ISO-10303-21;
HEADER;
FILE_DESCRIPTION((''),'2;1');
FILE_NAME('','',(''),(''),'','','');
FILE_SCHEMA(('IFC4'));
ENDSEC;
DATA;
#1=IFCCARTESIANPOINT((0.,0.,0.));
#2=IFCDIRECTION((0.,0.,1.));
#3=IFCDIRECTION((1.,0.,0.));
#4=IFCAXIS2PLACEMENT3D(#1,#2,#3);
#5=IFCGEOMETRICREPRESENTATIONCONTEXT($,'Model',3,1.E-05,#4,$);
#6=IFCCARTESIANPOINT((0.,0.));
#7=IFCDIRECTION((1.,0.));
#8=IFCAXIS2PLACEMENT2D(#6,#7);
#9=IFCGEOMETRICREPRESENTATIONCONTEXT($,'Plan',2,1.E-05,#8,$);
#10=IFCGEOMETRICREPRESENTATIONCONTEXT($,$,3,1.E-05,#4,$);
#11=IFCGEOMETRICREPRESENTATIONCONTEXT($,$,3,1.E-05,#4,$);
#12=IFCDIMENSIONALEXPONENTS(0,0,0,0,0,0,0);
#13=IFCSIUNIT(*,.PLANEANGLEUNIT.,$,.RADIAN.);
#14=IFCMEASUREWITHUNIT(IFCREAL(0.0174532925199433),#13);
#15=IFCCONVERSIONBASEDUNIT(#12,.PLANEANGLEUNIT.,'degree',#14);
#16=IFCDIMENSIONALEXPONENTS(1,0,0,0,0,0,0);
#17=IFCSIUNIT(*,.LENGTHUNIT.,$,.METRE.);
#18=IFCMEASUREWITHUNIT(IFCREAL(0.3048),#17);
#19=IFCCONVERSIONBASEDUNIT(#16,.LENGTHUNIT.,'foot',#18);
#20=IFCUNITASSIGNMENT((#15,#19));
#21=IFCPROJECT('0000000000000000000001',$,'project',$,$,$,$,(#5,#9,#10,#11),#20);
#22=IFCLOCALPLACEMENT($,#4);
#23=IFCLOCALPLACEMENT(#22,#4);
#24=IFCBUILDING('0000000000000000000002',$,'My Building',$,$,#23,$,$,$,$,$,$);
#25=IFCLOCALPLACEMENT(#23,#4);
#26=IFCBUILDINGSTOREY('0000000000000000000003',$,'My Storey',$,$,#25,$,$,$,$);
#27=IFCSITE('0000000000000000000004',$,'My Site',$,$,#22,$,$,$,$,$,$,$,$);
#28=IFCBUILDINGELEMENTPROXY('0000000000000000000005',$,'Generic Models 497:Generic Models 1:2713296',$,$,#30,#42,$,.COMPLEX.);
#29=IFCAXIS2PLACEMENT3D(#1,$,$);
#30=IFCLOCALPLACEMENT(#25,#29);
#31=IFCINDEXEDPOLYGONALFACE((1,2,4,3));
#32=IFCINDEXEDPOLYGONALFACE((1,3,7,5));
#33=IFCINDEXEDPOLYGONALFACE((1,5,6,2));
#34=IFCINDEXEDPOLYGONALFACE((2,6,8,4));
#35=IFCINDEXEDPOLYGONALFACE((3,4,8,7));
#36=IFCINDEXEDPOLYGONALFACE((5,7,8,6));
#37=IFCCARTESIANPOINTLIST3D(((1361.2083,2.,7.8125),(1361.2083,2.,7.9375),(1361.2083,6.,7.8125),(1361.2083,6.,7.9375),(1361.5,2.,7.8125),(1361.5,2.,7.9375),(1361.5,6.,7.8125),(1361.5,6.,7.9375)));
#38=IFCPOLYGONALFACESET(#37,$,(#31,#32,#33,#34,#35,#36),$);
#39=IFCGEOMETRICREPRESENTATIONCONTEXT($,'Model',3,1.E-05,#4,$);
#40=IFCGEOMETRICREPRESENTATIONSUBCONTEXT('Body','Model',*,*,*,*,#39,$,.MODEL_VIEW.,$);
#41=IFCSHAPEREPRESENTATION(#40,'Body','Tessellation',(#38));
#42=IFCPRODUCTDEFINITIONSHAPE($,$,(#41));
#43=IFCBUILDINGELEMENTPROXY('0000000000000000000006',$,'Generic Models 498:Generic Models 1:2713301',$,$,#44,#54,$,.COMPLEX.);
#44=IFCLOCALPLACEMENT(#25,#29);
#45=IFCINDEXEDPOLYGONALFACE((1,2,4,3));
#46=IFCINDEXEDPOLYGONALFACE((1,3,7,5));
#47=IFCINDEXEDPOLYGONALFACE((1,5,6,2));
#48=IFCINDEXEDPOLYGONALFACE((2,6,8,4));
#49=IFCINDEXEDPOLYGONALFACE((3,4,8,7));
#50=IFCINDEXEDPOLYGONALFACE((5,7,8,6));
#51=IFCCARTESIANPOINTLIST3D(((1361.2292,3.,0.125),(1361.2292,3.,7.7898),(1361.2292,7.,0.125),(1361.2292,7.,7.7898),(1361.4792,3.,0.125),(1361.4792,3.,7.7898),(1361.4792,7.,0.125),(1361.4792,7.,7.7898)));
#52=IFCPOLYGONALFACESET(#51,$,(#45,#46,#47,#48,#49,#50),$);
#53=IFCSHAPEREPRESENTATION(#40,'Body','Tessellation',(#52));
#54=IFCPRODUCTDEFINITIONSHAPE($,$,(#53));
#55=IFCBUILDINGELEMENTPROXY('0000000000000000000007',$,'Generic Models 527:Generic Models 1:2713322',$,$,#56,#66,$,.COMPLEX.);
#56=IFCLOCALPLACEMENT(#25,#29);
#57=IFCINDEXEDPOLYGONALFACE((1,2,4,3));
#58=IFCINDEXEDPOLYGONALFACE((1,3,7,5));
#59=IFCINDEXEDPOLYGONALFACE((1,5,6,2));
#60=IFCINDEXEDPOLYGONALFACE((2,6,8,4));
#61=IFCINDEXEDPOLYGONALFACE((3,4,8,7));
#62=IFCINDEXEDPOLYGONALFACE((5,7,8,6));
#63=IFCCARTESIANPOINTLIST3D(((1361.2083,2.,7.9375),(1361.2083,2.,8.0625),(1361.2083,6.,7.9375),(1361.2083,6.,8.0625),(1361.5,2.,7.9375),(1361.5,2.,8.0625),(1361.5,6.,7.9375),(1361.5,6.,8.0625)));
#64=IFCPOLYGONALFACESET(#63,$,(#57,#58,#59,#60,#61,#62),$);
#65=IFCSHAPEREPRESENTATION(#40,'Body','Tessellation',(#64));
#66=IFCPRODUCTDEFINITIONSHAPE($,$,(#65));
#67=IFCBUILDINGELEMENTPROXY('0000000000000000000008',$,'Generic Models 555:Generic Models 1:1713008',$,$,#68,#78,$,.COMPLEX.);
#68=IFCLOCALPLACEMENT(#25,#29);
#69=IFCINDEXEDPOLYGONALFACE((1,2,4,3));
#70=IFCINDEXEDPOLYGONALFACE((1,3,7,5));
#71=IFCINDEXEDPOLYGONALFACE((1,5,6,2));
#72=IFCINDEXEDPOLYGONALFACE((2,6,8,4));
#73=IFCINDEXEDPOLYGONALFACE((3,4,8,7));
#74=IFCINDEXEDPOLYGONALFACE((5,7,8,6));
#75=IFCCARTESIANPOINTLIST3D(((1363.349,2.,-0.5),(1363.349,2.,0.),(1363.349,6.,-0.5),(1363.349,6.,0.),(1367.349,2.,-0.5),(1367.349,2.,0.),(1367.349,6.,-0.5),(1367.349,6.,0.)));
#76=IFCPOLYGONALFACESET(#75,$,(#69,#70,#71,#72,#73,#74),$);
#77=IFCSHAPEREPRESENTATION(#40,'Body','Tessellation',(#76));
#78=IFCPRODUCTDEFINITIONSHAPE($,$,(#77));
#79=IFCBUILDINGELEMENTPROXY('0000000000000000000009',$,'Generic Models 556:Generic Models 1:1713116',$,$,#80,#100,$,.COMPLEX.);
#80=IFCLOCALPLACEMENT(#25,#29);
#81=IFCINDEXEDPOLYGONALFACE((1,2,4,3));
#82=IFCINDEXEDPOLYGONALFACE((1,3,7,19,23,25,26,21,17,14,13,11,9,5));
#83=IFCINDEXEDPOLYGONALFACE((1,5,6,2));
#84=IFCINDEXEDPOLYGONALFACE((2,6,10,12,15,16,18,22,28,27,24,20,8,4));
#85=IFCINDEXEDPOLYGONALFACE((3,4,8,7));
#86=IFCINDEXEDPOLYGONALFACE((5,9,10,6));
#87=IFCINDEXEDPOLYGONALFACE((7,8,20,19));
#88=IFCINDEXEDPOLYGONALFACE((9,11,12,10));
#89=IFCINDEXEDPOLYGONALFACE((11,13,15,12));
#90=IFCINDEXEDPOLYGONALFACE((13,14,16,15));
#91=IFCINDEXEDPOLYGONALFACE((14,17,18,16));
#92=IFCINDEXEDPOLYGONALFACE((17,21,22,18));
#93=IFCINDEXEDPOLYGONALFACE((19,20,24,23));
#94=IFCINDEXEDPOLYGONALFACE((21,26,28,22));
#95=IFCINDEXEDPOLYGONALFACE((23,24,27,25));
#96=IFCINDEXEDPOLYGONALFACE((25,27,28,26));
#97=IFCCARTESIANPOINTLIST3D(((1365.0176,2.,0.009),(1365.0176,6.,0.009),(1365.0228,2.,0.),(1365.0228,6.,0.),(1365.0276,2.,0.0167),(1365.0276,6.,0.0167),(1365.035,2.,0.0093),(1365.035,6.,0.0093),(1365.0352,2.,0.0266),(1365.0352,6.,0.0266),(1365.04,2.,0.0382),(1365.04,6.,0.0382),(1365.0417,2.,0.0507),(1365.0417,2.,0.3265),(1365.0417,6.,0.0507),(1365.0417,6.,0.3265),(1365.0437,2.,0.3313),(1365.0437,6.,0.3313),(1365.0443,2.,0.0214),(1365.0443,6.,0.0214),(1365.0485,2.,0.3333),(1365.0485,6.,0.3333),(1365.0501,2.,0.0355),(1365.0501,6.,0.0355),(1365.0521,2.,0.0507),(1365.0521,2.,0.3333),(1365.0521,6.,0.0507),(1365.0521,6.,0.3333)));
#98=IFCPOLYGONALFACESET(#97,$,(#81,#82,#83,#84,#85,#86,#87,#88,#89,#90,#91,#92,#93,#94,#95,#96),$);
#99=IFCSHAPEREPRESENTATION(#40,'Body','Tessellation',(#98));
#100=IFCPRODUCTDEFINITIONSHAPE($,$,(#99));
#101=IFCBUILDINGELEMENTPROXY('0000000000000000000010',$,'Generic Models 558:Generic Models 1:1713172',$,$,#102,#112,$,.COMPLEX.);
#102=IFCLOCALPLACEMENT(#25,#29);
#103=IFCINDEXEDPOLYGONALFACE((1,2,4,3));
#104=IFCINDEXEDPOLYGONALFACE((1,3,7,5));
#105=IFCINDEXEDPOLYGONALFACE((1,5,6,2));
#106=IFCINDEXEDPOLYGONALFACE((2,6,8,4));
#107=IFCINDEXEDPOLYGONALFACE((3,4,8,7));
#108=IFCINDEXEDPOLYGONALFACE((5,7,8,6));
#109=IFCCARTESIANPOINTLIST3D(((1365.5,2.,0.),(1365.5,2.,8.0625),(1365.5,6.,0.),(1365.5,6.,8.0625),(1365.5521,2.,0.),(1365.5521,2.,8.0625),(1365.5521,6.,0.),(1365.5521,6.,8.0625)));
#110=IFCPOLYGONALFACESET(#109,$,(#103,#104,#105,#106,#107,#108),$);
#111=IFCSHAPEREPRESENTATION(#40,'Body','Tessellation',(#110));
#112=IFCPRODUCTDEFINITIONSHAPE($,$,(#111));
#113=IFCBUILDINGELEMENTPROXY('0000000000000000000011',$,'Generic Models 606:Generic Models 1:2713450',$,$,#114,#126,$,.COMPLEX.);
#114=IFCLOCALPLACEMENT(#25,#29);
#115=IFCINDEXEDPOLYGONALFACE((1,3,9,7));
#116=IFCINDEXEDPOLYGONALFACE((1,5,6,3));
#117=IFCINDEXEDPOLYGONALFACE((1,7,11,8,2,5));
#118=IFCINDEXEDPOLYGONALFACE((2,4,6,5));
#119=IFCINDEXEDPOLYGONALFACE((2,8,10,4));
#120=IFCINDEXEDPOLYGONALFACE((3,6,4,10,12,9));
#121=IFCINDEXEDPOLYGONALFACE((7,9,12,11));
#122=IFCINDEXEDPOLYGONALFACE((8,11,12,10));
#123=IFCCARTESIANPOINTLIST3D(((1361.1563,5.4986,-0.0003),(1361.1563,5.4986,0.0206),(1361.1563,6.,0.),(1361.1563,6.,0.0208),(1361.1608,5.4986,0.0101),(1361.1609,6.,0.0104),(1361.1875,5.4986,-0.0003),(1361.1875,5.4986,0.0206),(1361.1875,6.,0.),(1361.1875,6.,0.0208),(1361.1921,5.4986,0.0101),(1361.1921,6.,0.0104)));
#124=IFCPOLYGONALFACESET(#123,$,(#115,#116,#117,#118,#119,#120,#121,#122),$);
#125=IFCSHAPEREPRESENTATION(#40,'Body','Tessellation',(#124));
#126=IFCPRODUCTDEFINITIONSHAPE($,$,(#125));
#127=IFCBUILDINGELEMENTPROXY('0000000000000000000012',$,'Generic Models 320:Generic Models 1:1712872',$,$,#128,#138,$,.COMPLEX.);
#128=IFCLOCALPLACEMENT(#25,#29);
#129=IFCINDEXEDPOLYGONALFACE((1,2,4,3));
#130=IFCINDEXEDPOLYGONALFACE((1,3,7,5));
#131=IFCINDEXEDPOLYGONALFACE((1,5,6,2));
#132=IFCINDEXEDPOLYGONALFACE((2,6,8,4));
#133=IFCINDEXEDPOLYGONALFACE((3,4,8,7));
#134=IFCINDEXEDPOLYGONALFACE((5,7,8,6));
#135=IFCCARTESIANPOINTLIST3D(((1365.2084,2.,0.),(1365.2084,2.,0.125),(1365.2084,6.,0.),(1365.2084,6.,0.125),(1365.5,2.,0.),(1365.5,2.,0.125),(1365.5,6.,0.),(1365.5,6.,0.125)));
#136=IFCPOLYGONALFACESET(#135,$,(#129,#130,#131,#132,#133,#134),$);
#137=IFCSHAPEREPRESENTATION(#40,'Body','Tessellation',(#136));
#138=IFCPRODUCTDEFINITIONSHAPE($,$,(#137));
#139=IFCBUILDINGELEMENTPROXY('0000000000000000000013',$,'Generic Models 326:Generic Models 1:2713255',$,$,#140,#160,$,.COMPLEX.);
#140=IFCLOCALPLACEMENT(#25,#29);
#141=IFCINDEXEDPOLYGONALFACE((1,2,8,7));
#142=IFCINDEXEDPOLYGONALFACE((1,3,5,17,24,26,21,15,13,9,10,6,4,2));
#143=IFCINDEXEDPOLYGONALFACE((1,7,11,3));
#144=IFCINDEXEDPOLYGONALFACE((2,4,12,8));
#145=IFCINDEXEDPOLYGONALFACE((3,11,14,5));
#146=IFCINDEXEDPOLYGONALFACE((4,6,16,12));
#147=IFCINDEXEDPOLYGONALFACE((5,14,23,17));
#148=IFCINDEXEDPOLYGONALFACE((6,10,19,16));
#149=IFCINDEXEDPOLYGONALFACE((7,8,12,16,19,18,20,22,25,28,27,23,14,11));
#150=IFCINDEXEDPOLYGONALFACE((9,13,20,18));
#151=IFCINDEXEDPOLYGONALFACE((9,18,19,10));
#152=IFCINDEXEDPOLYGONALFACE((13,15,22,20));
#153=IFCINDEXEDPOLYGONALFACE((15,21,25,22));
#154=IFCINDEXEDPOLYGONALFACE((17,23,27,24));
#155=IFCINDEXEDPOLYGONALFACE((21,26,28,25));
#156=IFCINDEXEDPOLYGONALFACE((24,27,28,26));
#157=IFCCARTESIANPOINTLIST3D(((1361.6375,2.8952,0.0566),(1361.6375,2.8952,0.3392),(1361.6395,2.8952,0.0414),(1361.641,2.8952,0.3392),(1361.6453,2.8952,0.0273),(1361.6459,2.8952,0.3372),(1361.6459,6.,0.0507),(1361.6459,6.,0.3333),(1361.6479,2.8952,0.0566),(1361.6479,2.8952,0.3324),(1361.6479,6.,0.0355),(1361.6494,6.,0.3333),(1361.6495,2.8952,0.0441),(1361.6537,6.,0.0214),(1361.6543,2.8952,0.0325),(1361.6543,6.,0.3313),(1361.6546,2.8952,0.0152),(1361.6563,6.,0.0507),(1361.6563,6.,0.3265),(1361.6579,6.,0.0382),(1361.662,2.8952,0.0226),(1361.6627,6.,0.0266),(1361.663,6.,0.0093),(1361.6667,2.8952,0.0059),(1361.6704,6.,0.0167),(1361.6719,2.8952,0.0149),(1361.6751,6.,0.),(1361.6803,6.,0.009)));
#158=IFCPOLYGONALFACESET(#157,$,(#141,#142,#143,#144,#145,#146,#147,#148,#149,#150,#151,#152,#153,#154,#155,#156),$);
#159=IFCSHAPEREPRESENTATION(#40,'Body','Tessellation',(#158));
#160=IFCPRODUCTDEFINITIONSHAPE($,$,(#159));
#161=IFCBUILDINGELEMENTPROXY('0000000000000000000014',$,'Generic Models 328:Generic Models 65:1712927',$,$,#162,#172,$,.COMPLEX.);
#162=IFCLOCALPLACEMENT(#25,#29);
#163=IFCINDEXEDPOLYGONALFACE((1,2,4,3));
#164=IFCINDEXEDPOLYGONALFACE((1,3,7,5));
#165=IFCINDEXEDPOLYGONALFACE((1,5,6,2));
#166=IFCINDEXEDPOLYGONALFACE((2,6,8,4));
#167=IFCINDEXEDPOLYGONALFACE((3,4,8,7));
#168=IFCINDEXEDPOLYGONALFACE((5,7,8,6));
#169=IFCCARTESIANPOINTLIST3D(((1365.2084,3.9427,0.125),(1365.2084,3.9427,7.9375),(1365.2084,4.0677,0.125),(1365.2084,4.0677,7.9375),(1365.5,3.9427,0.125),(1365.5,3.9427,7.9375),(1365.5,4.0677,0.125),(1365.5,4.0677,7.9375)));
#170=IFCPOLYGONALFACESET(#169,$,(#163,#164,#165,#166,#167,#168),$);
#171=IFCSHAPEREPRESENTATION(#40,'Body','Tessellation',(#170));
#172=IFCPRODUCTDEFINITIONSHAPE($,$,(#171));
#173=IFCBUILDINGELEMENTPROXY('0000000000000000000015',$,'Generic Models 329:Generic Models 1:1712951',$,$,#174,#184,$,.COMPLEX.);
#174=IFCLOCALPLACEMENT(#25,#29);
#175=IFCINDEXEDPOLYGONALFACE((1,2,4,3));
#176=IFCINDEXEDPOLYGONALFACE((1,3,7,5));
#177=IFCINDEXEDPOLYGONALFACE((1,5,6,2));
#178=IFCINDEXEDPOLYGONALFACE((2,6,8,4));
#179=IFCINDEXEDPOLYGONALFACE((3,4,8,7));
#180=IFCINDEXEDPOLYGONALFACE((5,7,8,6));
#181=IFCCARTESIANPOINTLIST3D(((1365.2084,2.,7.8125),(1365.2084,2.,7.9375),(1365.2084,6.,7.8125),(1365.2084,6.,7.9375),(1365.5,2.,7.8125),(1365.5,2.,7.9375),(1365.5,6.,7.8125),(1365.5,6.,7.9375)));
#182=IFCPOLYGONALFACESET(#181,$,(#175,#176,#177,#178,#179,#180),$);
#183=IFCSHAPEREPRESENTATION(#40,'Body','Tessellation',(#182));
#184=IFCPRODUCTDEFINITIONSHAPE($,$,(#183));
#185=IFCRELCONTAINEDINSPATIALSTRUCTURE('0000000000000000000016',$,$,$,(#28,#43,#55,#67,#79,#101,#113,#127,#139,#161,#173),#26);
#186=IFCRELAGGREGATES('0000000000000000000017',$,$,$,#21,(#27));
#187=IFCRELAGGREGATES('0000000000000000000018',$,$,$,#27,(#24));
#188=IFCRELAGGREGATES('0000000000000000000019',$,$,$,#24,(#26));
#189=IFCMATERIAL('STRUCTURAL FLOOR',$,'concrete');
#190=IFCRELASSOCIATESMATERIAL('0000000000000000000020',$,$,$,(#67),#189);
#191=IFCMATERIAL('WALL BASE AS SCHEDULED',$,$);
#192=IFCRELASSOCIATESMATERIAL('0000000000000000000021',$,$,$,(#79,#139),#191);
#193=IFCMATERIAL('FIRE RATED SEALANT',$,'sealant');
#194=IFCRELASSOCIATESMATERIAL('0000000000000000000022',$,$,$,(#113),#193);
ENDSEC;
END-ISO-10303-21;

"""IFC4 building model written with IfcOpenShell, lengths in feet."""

from ifc_helpers import new_model, entity, si_unit, converted_unit, frame, origin_with_axes, origin_2d_with_axis, place, context, subcontext, project, spatial, polyline, outline, extrude, material, element, save


model = new_model("IFC4")

# Units and contexts
model_context_1 = context("Model", 3, precision=1e-05, world=origin_with_axes())
plan_context = context("Plan", 2, precision=1e-05, world=origin_2d_with_axis())
model_context_2 = context("Model", 3, precision=1e-05, world=origin_with_axes())
context_of_model_1 = context(None, 3, precision=1e-05, world=origin_with_axes())
context_of_model_2 = context(None, 3, precision=1e-05, world=origin_with_axes())
body_context = subcontext(model_context_2, "Body", "Model", "MODEL_VIEW")
ifc_project = project(units=[converted_unit("PLANEANGLEUNIT", "degree", entity("IfcReal", 0.0174532925199433), si_unit("PLANEANGLEUNIT", "RADIAN"), dimensions=[0, 0, 0, 0, 0, 0, 0]), converted_unit("LENGTHUNIT", "foot", entity("IfcReal", 0.3048), si_unit("LENGTHUNIT", "METRE"), dimensions=[1, 0, 0, 0, 0, 0, 0])], contexts=[model_context_1, plan_context, context_of_model_1, context_of_model_2])

# Site, building, storey
site_placement = place(None, origin_with_axes())
site = spatial("IfcSite", under=ifc_project, at=site_placement, Name="My Site")
building_placement = place(site_placement, origin_with_axes())
building = spatial("IfcBuilding", under=site, at=building_placement, Name="My Building")
storey_placement = place(building_placement, origin_with_axes())
storey = spatial("IfcBuildingStorey", under=building, at=storey_placement, Name="My Storey")

# Building element proxies
proxy_1_placement = place(storey_placement, frame((1361.2083, 6.0, 7.8125), z_axis=(0.0, -1.0, 0.0), x_axis=(0.0, 0.0, 1.0)))
element("IfcBuildingElementProxy", 1, at=proxy_1_placement, inside=storey, Name="Generic Models 497:Generic Models 1:2713296", PredefinedType="COMPLEX", context=body_context, shape_type="SweptSolid", body=[
    extrude(outline(polyline([(-0.1458, -0.0625), (0.1458, -0.0625), (0.1458, 0.0625), (-0.1458, 0.0625), (-0.1458, -0.0625)])), frame((0.0625, -0.1458, 0.0), z_axis=(0.0, 0.0, -1.0), x_axis=(0.0, 1.0, 0.0)), (0.0, 0.0, -1.0), 4.0),
])
proxy_2_placement = place(storey_placement, frame((1361.2292, 3.0, 0.125), z_axis=(0.0, 0.0, 1.0), x_axis=(0.0, 1.0, 0.0)))
element("IfcBuildingElementProxy", 2, at=proxy_2_placement, inside=storey, Name="Generic Models 498:Generic Models 1:2713301", PredefinedType="COMPLEX", context=body_context, shape_type="SweptSolid", body=[
    extrude(outline(polyline([(-2.0, -0.125), (2.0, -0.125), (2.0, 0.125), (-2.0, 0.125), (-2.0, -0.125)])), frame((2.0, -0.125, 0.0), z_axis=(0.0, 0.0, -1.0), x_axis=(-1.0, 0.0, 0.0)), (0.0, 0.0, -1.0), 7.6648),
])
proxy_3_placement = place(storey_placement, frame((1361.2083, 6.0, 7.9375), z_axis=(0.0, -1.0, 0.0), x_axis=(0.0, 0.0, 1.0)))
element("IfcBuildingElementProxy", 3, at=proxy_3_placement, inside=storey, Name="Generic Models 527:Generic Models 1:2713322", PredefinedType="COMPLEX", context=body_context, shape_type="SweptSolid", body=[
    extrude(outline(polyline([(-0.1458, -0.0625), (0.1458, -0.0625), (0.1458, 0.0625), (-0.1458, 0.0625), (-0.1458, -0.0625)])), frame((0.0625, -0.1458, 0.0), z_axis=(0.0, 0.0, -1.0), x_axis=(0.0, 1.0, 0.0)), (0.0, 0.0, -1.0), 4.0),
])
ifc_material_1 = material(Name="FIRE RATED SEALANT", Category="sealant")
ifc_material_2 = material(Name="STRUCTURAL FLOOR", Category="concrete")
proxy_4_placement = place(storey_placement, frame((1363.349, 6.0, -0.5), z_axis=(0.0, -1.0, 0.0), x_axis=(0.0, 0.0, 1.0)))
element("IfcBuildingElementProxy", 4, at=proxy_4_placement, inside=storey, material=ifc_material_2, Name="Generic Models 555:Generic Models 1:1713008", PredefinedType="COMPLEX", context=body_context, shape_type="SweptSolid", body=[
    extrude(outline(polyline([(-0.25, -2.0), (0.25, -2.0), (0.25, 2.0), (-0.25, 2.0), (-0.25, -2.0)])), frame((0.25, -2.0, 0.0), z_axis=(0.0, 0.0, -1.0), x_axis=(1.0, 0.0, 0.0)), (0.0, 0.0, -1.0), 4.0),
])
ifc_material_3 = material(Name="WALL BASE AS SCHEDULED")
proxy_5_placement = place(storey_placement, frame((1365.0176, 6.0, 0.0), z_axis=(0.0, -1.0, 0.0), x_axis=(0.0, 0.0, 1.0)))
element("IfcBuildingElementProxy", 5, at=proxy_5_placement, inside=storey, material=ifc_material_3, Name="Generic Models 556:Generic Models 1:1713116", PredefinedType="COMPLEX", context=body_context, shape_type="SweptSolid", body=[
    extrude(outline(polyline([(0.2205, 0.0), (0.2206, 0.0036), (-0.0618, 0.0152), (-0.077, 0.0138), (-0.0914, 0.0086), (-0.1038, -0.0002), (-0.1136, -0.012), (-0.1048, -0.0175), (-0.0968, -0.0079), (-0.0865, -0.0007), (-0.0747, 0.0037), (-0.0622, 0.0048), (0.2133, -0.0066), (0.2183, -0.0048), (0.2205, 0.0)])), frame((0.113, -0.0218, 0.0), z_axis=(0.0, 0.0, -1.0), x_axis=(0.999153, -0.041137, 0.0)), (0.0, 0.0, -1.0), 4.0),
])
proxy_6_placement = place(storey_placement, frame((1365.5, 6.0, 0.0), z_axis=(0.0, -1.0, 0.0), x_axis=(0.0, 0.0, 1.0)))
element("IfcBuildingElementProxy", 6, at=proxy_6_placement, inside=storey, Name="Generic Models 558:Generic Models 1:1713172", PredefinedType="COMPLEX", context=body_context, shape_type="SweptSolid", body=[
    extrude(outline(polyline([(-4.0312, -0.026), (4.0312, -0.026), (4.0312, 0.026), (-4.0312, 0.026), (-4.0312, -0.026)])), frame((4.0312, -0.026, 0.0), z_axis=(0.0, 0.0, -1.0), x_axis=(1.0, 0.0, 0.0)), (0.0, 0.0, -1.0), 4.0),
])
proxy_7_placement = place(storey_placement, frame((1361.1563, 6.0, 0.0), z_axis=(0.0, -1.0, 0.0), x_axis=(0.0, 0.0, 1.0)))
element("IfcBuildingElementProxy", 7, at=proxy_7_placement, inside=storey, material=ifc_material_1, Name="Generic Models 606:Generic Models 1:2713450", PredefinedType="COMPLEX", context=body_context, shape_type="SweptSolid", body=[
    extrude(outline(polyline([(0.0201, 0.0), (-0.0066, 0.0162), (-0.016, 0.0097), (-0.0175, -0.0016), (0.0093, -0.0178), (0.0107, -0.0065), (0.0201, 0.0)])), frame((0.0104, -0.0172, 0.0), z_axis=(0.0, 0.0, -1.0), x_axis=(0.51911, 0.854708, 0.0)), (-0.000285, -0.000479, -1.0), 0.5014),
])
proxy_8_placement = place(storey_placement, frame((1365.2084, 6.0, 0.0), z_axis=(0.0, -1.0, 0.0), x_axis=(0.0, 0.0, 1.0)))
element("IfcBuildingElementProxy", 8, at=proxy_8_placement, inside=storey, Name="Generic Models 320:Generic Models 1:1712872", PredefinedType="COMPLEX", context=body_context, shape_type="SweptSolid", body=[
    extrude(outline(polyline([(-0.0625, -0.1458), (0.0625, -0.1458), (0.0625, 0.1458), (-0.0625, 0.1458), (-0.0625, -0.1458)])), frame((0.0625, -0.1458, 0.0), z_axis=(0.0, 0.0, -1.0), x_axis=(1.0, 0.0, 0.0)), (0.0, 0.0, -1.0), 4.0),
])
proxy_9_placement = place(storey_placement, frame((1361.6459, 6.0, 0.0), z_axis=(0.0, -1.0, 0.0), x_axis=(0.0, 0.0, 1.0)))
element("IfcBuildingElementProxy", 9, at=proxy_9_placement, inside=storey, material=ifc_material_3, Name="Generic Models 326:Generic Models 1:2713255", PredefinedType="COMPLEX", context=body_context, shape_type="SweptSolid", body=[
    extrude(outline(polyline([(-0.2134, 0.0022), (0.0624, 0.0022), (0.0748, 0.0006), (0.0864, -0.0042), (0.0964, -0.0119), (0.104, -0.0218), (0.113, -0.0166), (0.1037, -0.0045), (0.0916, 0.0048), (0.0775, 0.0106), (0.0624, 0.0126), (-0.2203, 0.0126), (-0.2203, 0.0091), (-0.2183, 0.0042), (-0.2134, 0.0022)])), frame((0.113, -0.0126, 0.0), z_axis=(0.0, 0.0, -1.0), x_axis=(-1.0, 0.0, 0.0)), (-0.001902, 0.002712, -0.999995), 3.1048),
])
proxy_10_placement = place(storey_placement, frame((1365.2084, 3.9427, 0.125), z_axis=(0.0, 0.0, 1.0), x_axis=(1.0, 0.0, 0.0)))
element("IfcBuildingElementProxy", 10, at=proxy_10_placement, inside=storey, Name="Generic Models 328:Generic Models 65:1712927", PredefinedType="COMPLEX", context=body_context, shape_type="SweptSolid", body=[
    extrude(outline(polyline([(-0.1458, -0.0625), (0.1458, -0.0625), (0.1458, 0.0625), (-0.1458, 0.0625), (-0.1458, -0.0625)])), frame((0.1458, 0.0625, 0.0), z_axis=(0.0, 0.0, -1.0), x_axis=(-1.0, 0.0, 0.0)), (0.0, 0.0, -1.0), 7.8125),
])
proxy_11_placement = place(storey_placement, frame((1365.2084, 6.0, 7.8125), z_axis=(0.0, -1.0, 0.0), x_axis=(0.0, 0.0, 1.0)))
element("IfcBuildingElementProxy", 11, at=proxy_11_placement, inside=storey, Name="Generic Models 329:Generic Models 1:1712951", PredefinedType="COMPLEX", context=body_context, shape_type="SweptSolid", body=[
    extrude(outline(polyline([(-0.1458, -0.0625), (0.1458, -0.0625), (0.1458, 0.0625), (-0.1458, 0.0625), (-0.1458, -0.0625)])), frame((0.0625, -0.1458, 0.0), z_axis=(0.0, 0.0, -1.0), x_axis=(0.0, 1.0, 0.0)), (0.0, 0.0, -1.0), 4.0),
])

save(model, "model.ifc")
